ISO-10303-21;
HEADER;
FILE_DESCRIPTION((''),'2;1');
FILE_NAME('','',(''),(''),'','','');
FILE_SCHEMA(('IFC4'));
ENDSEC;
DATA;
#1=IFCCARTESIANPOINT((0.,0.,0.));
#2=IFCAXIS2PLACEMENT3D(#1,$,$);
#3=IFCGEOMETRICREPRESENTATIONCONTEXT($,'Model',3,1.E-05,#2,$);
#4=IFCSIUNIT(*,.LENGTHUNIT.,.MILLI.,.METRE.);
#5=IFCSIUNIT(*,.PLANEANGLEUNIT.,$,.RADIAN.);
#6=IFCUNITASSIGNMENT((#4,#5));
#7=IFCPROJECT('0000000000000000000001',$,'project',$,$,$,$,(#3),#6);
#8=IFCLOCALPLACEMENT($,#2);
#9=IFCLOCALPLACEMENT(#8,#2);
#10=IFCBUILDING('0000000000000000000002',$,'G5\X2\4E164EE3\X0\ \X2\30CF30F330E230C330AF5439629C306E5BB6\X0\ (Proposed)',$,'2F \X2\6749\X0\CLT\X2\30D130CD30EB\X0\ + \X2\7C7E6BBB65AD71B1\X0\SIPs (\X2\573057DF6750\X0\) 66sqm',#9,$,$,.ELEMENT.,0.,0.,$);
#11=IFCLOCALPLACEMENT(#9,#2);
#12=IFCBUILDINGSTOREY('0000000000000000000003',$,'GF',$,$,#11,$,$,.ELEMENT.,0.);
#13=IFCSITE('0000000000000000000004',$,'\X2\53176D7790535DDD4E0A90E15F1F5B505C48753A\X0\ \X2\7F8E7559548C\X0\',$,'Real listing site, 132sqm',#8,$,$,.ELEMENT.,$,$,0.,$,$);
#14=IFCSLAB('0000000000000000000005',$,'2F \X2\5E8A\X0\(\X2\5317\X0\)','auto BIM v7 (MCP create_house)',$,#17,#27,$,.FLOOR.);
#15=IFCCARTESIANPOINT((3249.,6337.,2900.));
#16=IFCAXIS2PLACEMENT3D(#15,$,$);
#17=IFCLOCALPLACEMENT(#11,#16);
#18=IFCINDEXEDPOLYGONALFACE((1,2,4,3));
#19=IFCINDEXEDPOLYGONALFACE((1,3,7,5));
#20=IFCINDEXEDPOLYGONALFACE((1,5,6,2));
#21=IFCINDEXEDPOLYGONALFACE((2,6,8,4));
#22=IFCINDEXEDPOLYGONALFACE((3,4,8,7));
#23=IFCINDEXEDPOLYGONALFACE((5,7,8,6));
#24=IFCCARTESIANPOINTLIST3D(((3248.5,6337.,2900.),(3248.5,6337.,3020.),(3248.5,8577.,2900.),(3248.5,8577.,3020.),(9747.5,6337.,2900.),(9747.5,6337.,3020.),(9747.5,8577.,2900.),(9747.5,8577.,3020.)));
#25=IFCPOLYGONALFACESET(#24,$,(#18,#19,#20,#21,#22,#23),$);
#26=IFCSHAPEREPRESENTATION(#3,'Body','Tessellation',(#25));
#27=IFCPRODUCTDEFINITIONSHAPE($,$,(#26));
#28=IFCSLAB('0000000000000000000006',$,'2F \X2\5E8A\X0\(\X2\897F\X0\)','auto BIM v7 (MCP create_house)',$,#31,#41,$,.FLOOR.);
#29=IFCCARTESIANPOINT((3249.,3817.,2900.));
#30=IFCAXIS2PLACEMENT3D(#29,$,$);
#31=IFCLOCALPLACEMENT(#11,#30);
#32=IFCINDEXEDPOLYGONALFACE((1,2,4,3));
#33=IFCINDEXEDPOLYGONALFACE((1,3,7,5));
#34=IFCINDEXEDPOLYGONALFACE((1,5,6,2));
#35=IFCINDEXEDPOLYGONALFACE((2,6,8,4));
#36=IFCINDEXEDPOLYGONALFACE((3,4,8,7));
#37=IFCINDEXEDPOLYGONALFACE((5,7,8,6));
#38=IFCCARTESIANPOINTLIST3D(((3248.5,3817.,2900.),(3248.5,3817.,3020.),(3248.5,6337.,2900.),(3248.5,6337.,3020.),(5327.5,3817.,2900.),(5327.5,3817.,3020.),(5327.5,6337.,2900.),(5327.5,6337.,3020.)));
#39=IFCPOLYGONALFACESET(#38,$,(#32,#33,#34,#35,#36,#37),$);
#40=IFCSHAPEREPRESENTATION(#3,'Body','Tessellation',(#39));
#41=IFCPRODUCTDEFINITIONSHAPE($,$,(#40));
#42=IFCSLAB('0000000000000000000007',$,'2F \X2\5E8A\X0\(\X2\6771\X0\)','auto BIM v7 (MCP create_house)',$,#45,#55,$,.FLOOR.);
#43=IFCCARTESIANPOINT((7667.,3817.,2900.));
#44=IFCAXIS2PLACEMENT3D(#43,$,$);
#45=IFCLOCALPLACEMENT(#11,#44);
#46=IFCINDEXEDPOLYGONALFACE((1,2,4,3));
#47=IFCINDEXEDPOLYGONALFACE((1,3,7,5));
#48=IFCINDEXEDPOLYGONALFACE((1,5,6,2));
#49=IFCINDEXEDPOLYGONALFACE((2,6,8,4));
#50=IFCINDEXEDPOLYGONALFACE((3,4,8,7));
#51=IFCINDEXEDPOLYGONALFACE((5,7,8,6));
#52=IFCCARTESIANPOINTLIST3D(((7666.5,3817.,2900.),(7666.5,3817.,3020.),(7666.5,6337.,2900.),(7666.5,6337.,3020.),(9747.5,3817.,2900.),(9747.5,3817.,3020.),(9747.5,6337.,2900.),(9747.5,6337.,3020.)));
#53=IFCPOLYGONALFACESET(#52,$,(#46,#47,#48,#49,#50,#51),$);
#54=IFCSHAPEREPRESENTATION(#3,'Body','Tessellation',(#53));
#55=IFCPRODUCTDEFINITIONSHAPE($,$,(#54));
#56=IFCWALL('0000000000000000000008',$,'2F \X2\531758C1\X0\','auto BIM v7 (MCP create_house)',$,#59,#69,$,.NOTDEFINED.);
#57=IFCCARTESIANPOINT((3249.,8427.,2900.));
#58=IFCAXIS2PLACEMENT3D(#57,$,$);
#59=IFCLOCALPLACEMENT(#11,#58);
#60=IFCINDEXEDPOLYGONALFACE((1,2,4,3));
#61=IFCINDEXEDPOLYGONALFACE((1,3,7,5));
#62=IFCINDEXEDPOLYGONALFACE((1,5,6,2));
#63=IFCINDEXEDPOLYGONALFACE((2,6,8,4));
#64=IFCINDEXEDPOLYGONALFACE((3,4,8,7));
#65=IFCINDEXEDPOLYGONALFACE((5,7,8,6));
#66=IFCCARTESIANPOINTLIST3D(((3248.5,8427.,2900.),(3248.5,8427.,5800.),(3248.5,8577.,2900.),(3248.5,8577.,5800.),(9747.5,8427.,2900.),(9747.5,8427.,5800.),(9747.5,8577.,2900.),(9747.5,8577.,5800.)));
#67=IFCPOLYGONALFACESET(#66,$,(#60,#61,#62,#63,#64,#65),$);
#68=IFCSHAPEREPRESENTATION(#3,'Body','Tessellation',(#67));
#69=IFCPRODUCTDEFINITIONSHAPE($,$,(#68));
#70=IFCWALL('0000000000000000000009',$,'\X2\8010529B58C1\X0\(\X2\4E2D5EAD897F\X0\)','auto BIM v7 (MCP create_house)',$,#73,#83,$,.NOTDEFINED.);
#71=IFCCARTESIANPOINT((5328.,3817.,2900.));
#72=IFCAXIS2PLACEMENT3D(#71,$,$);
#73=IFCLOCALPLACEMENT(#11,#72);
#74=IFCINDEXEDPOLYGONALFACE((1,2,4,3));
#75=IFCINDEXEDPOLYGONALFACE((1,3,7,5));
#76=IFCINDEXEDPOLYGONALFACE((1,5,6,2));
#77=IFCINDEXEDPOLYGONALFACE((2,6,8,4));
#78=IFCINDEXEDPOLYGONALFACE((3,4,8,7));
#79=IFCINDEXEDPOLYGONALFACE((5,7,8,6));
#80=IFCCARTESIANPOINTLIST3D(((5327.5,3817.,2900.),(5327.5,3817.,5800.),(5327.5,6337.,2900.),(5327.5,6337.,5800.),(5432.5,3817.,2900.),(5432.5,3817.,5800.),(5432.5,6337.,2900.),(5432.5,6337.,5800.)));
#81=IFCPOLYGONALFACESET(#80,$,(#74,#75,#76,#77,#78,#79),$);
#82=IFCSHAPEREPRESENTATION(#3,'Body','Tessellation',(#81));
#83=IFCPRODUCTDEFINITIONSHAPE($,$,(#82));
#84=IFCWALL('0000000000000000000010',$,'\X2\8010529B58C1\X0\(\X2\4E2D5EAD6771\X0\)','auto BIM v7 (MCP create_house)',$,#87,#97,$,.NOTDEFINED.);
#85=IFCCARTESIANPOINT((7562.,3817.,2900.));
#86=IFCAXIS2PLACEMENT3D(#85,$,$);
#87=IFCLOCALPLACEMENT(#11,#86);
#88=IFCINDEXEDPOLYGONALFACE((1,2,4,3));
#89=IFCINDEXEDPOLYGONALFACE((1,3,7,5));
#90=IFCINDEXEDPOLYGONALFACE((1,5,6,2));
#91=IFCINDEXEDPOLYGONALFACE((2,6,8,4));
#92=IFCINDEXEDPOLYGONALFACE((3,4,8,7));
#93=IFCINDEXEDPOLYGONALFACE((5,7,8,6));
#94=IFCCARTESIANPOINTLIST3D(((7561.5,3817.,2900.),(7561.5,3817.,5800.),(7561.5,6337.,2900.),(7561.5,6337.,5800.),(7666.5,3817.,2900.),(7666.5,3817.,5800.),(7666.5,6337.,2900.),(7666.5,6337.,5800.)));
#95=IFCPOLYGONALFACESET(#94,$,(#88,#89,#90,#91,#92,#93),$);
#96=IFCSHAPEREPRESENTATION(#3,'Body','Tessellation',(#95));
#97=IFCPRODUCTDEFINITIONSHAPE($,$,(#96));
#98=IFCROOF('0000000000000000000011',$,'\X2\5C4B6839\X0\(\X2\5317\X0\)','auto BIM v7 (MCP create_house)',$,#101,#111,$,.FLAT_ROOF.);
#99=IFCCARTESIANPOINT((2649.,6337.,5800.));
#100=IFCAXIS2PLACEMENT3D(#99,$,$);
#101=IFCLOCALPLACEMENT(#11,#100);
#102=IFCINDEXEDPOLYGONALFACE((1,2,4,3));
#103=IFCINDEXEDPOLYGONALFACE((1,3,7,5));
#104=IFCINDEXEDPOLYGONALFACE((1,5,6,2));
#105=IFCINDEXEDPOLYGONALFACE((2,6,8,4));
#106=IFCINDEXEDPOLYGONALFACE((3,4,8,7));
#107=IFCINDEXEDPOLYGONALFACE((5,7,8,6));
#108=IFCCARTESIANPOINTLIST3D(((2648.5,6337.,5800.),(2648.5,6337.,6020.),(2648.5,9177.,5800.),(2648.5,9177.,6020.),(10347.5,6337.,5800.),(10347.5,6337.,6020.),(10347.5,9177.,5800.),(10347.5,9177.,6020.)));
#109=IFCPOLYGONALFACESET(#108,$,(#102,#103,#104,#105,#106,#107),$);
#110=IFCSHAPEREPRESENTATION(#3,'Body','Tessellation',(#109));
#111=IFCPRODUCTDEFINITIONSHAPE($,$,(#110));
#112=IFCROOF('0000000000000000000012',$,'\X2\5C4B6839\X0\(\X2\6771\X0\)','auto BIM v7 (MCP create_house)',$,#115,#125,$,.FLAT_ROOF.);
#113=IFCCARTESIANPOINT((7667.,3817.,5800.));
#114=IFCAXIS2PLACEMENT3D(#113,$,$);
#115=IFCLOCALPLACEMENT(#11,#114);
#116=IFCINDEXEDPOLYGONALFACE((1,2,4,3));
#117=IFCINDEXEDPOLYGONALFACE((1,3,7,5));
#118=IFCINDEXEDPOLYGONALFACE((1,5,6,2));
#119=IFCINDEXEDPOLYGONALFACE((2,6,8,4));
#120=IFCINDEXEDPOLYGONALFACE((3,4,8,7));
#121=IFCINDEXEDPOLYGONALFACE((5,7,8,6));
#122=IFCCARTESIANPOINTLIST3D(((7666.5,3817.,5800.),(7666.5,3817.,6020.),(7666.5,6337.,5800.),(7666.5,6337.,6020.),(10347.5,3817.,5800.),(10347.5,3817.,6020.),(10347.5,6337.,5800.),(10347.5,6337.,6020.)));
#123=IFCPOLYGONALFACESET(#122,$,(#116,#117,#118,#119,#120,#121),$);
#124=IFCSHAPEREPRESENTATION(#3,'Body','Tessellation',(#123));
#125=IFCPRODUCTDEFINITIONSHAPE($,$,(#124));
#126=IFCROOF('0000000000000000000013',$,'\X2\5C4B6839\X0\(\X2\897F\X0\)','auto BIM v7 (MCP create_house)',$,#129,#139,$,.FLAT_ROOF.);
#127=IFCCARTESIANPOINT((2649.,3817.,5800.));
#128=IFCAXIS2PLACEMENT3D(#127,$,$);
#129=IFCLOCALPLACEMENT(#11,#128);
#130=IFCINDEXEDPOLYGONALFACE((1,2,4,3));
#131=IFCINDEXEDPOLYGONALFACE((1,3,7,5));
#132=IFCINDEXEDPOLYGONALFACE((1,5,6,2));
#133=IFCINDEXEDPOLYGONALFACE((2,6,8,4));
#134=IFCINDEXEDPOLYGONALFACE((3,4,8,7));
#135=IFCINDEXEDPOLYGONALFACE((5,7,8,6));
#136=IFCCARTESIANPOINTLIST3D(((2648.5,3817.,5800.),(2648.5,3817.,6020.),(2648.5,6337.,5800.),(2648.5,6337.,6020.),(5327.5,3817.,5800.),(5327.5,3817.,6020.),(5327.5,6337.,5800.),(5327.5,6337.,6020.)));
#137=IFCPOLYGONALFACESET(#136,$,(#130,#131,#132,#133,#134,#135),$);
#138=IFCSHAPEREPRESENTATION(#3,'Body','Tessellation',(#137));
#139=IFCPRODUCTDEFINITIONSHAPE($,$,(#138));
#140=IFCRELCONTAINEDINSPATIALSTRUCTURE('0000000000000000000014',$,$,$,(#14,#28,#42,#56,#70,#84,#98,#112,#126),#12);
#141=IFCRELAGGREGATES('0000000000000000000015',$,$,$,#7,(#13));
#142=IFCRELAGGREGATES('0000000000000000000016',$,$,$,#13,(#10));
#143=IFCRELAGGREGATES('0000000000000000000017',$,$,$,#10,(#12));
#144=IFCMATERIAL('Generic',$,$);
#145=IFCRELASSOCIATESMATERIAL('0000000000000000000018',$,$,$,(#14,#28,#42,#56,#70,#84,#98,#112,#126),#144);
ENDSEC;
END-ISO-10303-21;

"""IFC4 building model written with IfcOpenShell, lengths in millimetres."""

from ifc_helpers import new_model, si_unit, frame, frame_2d, origin, place, context, project, spatial, rectangle, extrude, material, element, save


model = new_model("IFC4")

# Units and contexts
model_context = context("Model", 3, precision=1e-05, world=origin())
ifc_project = project(units=[si_unit("LENGTHUNIT", "METRE", prefix="MILLI"), si_unit("PLANEANGLEUNIT", "RADIAN")], contexts=[model_context])

# Site, building, storey
site_placement = place(None, origin())
site = spatial("IfcSite", under=ifc_project, at=site_placement, Name="北海道川上郡弟子屈町 美留和", ObjectType="Real listing site, 132sqm", CompositionType="ELEMENT", RefElevation=0.0)
building_placement = place(site_placement, origin())
building = spatial("IfcBuilding", under=site, at=building_placement, Name="G5世代 ハンモック吹抜の家 (Proposed)", ObjectType="2F 杉CLTパネル + 籾殻断熱SIPs (地域材) 66sqm", CompositionType="ELEMENT", ElevationOfRefHeight=0.0, ElevationOfTerrain=0.0)
storey_placement = place(building_placement, origin())
storey = spatial("IfcBuildingStorey", under=building, at=storey_placement, Name="GF", CompositionType="ELEMENT", Elevation=0.0)

# Slabs
ifc_material = material(Name="Generic")
slab_1_placement = place(storey_placement, frame((3249.0, 6337.0, 2900.0)))
element("IfcSlab", 1, at=slab_1_placement, inside=storey, material=ifc_material, Name="2F 床(北)", Description="auto BIM v7 (MCP create_house)", PredefinedType="FLOOR", context=model_context, shape_type="SweptSolid", body=[
    extrude(rectangle(XDim=6499.0, YDim=2240.0, at=frame_2d((3249.0, 1120.0))), frame((3249.0, 6337.0, 2900.0)), (0.0, 0.0, 1.0), 120.0),
])
slab_2_placement = place(storey_placement, frame((3249.0, 3817.0, 2900.0)))
element("IfcSlab", 2, at=slab_2_placement, inside=storey, material=ifc_material, Name="2F 床(西)", Description="auto BIM v7 (MCP create_house)", PredefinedType="FLOOR", context=model_context, shape_type="SweptSolid", body=[
    extrude(rectangle(XDim=2079.0, YDim=2520.0, at=frame_2d((1039.0, 1260.0))), frame((3249.0, 3817.0, 2900.0)), (0.0, 0.0, 1.0), 120.0),
])
slab_3_placement = place(storey_placement, frame((7667.0, 3817.0, 2900.0)))
element("IfcSlab", 3, at=slab_3_placement, inside=storey, material=ifc_material, Name="2F 床(東)", Description="auto BIM v7 (MCP create_house)", PredefinedType="FLOOR", context=model_context, shape_type="SweptSolid", body=[
    extrude(rectangle(XDim=2081.0, YDim=2520.0, at=frame_2d((1040.0, 1260.0))), frame((7667.0, 3817.0, 2900.0)), (0.0, 0.0, 1.0), 120.0),
])

# Wall
wall_1_placement = place(storey_placement, frame((3249.0, 8427.0, 2900.0)))
element("IfcWall", 4, at=wall_1_placement, inside=storey, material=ifc_material, Name="2F 北壁", Description="auto BIM v7 (MCP create_house)", PredefinedType="NOTDEFINED", context=model_context, shape_type="SweptSolid", body=[
    extrude(rectangle(XDim=6499.0, YDim=150.0, at=frame_2d((3249.0, 75.0))), frame((3249.0, 8427.0, 2900.0)), (0.0, 0.0, 1.0), 2900.0),
])

# Walls
wall_2_placement = place(storey_placement, frame((5328.0, 3817.0, 2900.0)))
element("IfcWall", 5, at=wall_2_placement, inside=storey, material=ifc_material, Name="耐力壁(中庭西)", Description="auto BIM v7 (MCP create_house)", PredefinedType="NOTDEFINED", context=model_context, shape_type="SweptSolid", body=[
    extrude(rectangle(XDim=105.0, YDim=2520.0, at=frame_2d((52.0, 1260.0))), frame((5328.0, 3817.0, 2900.0)), (0.0, 0.0, 1.0), 2900.0),
])
wall_3_placement = place(storey_placement, frame((7562.0, 3817.0, 2900.0)))
element("IfcWall", 6, at=wall_3_placement, inside=storey, material=ifc_material, Name="耐力壁(中庭東)", Description="auto BIM v7 (MCP create_house)", PredefinedType="NOTDEFINED", context=model_context, shape_type="SweptSolid", body=[
    extrude(rectangle(XDim=105.0, YDim=2520.0, at=frame_2d((52.0, 1260.0))), frame((7562.0, 3817.0, 2900.0)), (0.0, 0.0, 1.0), 2900.0),
])

# Roofs
roof_1_placement = place(storey_placement, frame((2649.0, 6337.0, 5800.0)))
element("IfcRoof", 7, at=roof_1_placement, inside=storey, material=ifc_material, Name="屋根(北)", Description="auto BIM v7 (MCP create_house)", PredefinedType="FLAT_ROOF", context=model_context, shape_type="SweptSolid", body=[
    extrude(rectangle(XDim=7699.0, YDim=2840.0, at=frame_2d((3849.0, 1420.0))), frame((2649.0, 6337.0, 5800.0)), (0.0, 0.0, 1.0), 220.0),
])
roof_2_placement = place(storey_placement, frame((7667.0, 3817.0, 5800.0)))
element("IfcRoof", 8, at=roof_2_placement, inside=storey, material=ifc_material, Name="屋根(東)", Description="auto BIM v7 (MCP create_house)", PredefinedType="FLAT_ROOF", context=model_context, shape_type="SweptSolid", body=[
    extrude(rectangle(XDim=2681.0, YDim=2520.0, at=frame_2d((1340.0, 1260.0))), frame((7667.0, 3817.0, 5800.0)), (0.0, 0.0, 1.0), 220.0),
])
roof_3_placement = place(storey_placement, frame((2649.0, 3817.0, 5800.0)))
element("IfcRoof", 9, at=roof_3_placement, inside=storey, material=ifc_material, Name="屋根(西)", Description="auto BIM v7 (MCP create_house)", PredefinedType="FLAT_ROOF", context=model_context, shape_type="SweptSolid", body=[
    extrude(rectangle(XDim=2679.0, YDim=2520.0, at=frame_2d((1339.0, 1260.0))), frame((2649.0, 3817.0, 5800.0)), (0.0, 0.0, 1.0), 220.0),
])

save(model, "model.ifc")
